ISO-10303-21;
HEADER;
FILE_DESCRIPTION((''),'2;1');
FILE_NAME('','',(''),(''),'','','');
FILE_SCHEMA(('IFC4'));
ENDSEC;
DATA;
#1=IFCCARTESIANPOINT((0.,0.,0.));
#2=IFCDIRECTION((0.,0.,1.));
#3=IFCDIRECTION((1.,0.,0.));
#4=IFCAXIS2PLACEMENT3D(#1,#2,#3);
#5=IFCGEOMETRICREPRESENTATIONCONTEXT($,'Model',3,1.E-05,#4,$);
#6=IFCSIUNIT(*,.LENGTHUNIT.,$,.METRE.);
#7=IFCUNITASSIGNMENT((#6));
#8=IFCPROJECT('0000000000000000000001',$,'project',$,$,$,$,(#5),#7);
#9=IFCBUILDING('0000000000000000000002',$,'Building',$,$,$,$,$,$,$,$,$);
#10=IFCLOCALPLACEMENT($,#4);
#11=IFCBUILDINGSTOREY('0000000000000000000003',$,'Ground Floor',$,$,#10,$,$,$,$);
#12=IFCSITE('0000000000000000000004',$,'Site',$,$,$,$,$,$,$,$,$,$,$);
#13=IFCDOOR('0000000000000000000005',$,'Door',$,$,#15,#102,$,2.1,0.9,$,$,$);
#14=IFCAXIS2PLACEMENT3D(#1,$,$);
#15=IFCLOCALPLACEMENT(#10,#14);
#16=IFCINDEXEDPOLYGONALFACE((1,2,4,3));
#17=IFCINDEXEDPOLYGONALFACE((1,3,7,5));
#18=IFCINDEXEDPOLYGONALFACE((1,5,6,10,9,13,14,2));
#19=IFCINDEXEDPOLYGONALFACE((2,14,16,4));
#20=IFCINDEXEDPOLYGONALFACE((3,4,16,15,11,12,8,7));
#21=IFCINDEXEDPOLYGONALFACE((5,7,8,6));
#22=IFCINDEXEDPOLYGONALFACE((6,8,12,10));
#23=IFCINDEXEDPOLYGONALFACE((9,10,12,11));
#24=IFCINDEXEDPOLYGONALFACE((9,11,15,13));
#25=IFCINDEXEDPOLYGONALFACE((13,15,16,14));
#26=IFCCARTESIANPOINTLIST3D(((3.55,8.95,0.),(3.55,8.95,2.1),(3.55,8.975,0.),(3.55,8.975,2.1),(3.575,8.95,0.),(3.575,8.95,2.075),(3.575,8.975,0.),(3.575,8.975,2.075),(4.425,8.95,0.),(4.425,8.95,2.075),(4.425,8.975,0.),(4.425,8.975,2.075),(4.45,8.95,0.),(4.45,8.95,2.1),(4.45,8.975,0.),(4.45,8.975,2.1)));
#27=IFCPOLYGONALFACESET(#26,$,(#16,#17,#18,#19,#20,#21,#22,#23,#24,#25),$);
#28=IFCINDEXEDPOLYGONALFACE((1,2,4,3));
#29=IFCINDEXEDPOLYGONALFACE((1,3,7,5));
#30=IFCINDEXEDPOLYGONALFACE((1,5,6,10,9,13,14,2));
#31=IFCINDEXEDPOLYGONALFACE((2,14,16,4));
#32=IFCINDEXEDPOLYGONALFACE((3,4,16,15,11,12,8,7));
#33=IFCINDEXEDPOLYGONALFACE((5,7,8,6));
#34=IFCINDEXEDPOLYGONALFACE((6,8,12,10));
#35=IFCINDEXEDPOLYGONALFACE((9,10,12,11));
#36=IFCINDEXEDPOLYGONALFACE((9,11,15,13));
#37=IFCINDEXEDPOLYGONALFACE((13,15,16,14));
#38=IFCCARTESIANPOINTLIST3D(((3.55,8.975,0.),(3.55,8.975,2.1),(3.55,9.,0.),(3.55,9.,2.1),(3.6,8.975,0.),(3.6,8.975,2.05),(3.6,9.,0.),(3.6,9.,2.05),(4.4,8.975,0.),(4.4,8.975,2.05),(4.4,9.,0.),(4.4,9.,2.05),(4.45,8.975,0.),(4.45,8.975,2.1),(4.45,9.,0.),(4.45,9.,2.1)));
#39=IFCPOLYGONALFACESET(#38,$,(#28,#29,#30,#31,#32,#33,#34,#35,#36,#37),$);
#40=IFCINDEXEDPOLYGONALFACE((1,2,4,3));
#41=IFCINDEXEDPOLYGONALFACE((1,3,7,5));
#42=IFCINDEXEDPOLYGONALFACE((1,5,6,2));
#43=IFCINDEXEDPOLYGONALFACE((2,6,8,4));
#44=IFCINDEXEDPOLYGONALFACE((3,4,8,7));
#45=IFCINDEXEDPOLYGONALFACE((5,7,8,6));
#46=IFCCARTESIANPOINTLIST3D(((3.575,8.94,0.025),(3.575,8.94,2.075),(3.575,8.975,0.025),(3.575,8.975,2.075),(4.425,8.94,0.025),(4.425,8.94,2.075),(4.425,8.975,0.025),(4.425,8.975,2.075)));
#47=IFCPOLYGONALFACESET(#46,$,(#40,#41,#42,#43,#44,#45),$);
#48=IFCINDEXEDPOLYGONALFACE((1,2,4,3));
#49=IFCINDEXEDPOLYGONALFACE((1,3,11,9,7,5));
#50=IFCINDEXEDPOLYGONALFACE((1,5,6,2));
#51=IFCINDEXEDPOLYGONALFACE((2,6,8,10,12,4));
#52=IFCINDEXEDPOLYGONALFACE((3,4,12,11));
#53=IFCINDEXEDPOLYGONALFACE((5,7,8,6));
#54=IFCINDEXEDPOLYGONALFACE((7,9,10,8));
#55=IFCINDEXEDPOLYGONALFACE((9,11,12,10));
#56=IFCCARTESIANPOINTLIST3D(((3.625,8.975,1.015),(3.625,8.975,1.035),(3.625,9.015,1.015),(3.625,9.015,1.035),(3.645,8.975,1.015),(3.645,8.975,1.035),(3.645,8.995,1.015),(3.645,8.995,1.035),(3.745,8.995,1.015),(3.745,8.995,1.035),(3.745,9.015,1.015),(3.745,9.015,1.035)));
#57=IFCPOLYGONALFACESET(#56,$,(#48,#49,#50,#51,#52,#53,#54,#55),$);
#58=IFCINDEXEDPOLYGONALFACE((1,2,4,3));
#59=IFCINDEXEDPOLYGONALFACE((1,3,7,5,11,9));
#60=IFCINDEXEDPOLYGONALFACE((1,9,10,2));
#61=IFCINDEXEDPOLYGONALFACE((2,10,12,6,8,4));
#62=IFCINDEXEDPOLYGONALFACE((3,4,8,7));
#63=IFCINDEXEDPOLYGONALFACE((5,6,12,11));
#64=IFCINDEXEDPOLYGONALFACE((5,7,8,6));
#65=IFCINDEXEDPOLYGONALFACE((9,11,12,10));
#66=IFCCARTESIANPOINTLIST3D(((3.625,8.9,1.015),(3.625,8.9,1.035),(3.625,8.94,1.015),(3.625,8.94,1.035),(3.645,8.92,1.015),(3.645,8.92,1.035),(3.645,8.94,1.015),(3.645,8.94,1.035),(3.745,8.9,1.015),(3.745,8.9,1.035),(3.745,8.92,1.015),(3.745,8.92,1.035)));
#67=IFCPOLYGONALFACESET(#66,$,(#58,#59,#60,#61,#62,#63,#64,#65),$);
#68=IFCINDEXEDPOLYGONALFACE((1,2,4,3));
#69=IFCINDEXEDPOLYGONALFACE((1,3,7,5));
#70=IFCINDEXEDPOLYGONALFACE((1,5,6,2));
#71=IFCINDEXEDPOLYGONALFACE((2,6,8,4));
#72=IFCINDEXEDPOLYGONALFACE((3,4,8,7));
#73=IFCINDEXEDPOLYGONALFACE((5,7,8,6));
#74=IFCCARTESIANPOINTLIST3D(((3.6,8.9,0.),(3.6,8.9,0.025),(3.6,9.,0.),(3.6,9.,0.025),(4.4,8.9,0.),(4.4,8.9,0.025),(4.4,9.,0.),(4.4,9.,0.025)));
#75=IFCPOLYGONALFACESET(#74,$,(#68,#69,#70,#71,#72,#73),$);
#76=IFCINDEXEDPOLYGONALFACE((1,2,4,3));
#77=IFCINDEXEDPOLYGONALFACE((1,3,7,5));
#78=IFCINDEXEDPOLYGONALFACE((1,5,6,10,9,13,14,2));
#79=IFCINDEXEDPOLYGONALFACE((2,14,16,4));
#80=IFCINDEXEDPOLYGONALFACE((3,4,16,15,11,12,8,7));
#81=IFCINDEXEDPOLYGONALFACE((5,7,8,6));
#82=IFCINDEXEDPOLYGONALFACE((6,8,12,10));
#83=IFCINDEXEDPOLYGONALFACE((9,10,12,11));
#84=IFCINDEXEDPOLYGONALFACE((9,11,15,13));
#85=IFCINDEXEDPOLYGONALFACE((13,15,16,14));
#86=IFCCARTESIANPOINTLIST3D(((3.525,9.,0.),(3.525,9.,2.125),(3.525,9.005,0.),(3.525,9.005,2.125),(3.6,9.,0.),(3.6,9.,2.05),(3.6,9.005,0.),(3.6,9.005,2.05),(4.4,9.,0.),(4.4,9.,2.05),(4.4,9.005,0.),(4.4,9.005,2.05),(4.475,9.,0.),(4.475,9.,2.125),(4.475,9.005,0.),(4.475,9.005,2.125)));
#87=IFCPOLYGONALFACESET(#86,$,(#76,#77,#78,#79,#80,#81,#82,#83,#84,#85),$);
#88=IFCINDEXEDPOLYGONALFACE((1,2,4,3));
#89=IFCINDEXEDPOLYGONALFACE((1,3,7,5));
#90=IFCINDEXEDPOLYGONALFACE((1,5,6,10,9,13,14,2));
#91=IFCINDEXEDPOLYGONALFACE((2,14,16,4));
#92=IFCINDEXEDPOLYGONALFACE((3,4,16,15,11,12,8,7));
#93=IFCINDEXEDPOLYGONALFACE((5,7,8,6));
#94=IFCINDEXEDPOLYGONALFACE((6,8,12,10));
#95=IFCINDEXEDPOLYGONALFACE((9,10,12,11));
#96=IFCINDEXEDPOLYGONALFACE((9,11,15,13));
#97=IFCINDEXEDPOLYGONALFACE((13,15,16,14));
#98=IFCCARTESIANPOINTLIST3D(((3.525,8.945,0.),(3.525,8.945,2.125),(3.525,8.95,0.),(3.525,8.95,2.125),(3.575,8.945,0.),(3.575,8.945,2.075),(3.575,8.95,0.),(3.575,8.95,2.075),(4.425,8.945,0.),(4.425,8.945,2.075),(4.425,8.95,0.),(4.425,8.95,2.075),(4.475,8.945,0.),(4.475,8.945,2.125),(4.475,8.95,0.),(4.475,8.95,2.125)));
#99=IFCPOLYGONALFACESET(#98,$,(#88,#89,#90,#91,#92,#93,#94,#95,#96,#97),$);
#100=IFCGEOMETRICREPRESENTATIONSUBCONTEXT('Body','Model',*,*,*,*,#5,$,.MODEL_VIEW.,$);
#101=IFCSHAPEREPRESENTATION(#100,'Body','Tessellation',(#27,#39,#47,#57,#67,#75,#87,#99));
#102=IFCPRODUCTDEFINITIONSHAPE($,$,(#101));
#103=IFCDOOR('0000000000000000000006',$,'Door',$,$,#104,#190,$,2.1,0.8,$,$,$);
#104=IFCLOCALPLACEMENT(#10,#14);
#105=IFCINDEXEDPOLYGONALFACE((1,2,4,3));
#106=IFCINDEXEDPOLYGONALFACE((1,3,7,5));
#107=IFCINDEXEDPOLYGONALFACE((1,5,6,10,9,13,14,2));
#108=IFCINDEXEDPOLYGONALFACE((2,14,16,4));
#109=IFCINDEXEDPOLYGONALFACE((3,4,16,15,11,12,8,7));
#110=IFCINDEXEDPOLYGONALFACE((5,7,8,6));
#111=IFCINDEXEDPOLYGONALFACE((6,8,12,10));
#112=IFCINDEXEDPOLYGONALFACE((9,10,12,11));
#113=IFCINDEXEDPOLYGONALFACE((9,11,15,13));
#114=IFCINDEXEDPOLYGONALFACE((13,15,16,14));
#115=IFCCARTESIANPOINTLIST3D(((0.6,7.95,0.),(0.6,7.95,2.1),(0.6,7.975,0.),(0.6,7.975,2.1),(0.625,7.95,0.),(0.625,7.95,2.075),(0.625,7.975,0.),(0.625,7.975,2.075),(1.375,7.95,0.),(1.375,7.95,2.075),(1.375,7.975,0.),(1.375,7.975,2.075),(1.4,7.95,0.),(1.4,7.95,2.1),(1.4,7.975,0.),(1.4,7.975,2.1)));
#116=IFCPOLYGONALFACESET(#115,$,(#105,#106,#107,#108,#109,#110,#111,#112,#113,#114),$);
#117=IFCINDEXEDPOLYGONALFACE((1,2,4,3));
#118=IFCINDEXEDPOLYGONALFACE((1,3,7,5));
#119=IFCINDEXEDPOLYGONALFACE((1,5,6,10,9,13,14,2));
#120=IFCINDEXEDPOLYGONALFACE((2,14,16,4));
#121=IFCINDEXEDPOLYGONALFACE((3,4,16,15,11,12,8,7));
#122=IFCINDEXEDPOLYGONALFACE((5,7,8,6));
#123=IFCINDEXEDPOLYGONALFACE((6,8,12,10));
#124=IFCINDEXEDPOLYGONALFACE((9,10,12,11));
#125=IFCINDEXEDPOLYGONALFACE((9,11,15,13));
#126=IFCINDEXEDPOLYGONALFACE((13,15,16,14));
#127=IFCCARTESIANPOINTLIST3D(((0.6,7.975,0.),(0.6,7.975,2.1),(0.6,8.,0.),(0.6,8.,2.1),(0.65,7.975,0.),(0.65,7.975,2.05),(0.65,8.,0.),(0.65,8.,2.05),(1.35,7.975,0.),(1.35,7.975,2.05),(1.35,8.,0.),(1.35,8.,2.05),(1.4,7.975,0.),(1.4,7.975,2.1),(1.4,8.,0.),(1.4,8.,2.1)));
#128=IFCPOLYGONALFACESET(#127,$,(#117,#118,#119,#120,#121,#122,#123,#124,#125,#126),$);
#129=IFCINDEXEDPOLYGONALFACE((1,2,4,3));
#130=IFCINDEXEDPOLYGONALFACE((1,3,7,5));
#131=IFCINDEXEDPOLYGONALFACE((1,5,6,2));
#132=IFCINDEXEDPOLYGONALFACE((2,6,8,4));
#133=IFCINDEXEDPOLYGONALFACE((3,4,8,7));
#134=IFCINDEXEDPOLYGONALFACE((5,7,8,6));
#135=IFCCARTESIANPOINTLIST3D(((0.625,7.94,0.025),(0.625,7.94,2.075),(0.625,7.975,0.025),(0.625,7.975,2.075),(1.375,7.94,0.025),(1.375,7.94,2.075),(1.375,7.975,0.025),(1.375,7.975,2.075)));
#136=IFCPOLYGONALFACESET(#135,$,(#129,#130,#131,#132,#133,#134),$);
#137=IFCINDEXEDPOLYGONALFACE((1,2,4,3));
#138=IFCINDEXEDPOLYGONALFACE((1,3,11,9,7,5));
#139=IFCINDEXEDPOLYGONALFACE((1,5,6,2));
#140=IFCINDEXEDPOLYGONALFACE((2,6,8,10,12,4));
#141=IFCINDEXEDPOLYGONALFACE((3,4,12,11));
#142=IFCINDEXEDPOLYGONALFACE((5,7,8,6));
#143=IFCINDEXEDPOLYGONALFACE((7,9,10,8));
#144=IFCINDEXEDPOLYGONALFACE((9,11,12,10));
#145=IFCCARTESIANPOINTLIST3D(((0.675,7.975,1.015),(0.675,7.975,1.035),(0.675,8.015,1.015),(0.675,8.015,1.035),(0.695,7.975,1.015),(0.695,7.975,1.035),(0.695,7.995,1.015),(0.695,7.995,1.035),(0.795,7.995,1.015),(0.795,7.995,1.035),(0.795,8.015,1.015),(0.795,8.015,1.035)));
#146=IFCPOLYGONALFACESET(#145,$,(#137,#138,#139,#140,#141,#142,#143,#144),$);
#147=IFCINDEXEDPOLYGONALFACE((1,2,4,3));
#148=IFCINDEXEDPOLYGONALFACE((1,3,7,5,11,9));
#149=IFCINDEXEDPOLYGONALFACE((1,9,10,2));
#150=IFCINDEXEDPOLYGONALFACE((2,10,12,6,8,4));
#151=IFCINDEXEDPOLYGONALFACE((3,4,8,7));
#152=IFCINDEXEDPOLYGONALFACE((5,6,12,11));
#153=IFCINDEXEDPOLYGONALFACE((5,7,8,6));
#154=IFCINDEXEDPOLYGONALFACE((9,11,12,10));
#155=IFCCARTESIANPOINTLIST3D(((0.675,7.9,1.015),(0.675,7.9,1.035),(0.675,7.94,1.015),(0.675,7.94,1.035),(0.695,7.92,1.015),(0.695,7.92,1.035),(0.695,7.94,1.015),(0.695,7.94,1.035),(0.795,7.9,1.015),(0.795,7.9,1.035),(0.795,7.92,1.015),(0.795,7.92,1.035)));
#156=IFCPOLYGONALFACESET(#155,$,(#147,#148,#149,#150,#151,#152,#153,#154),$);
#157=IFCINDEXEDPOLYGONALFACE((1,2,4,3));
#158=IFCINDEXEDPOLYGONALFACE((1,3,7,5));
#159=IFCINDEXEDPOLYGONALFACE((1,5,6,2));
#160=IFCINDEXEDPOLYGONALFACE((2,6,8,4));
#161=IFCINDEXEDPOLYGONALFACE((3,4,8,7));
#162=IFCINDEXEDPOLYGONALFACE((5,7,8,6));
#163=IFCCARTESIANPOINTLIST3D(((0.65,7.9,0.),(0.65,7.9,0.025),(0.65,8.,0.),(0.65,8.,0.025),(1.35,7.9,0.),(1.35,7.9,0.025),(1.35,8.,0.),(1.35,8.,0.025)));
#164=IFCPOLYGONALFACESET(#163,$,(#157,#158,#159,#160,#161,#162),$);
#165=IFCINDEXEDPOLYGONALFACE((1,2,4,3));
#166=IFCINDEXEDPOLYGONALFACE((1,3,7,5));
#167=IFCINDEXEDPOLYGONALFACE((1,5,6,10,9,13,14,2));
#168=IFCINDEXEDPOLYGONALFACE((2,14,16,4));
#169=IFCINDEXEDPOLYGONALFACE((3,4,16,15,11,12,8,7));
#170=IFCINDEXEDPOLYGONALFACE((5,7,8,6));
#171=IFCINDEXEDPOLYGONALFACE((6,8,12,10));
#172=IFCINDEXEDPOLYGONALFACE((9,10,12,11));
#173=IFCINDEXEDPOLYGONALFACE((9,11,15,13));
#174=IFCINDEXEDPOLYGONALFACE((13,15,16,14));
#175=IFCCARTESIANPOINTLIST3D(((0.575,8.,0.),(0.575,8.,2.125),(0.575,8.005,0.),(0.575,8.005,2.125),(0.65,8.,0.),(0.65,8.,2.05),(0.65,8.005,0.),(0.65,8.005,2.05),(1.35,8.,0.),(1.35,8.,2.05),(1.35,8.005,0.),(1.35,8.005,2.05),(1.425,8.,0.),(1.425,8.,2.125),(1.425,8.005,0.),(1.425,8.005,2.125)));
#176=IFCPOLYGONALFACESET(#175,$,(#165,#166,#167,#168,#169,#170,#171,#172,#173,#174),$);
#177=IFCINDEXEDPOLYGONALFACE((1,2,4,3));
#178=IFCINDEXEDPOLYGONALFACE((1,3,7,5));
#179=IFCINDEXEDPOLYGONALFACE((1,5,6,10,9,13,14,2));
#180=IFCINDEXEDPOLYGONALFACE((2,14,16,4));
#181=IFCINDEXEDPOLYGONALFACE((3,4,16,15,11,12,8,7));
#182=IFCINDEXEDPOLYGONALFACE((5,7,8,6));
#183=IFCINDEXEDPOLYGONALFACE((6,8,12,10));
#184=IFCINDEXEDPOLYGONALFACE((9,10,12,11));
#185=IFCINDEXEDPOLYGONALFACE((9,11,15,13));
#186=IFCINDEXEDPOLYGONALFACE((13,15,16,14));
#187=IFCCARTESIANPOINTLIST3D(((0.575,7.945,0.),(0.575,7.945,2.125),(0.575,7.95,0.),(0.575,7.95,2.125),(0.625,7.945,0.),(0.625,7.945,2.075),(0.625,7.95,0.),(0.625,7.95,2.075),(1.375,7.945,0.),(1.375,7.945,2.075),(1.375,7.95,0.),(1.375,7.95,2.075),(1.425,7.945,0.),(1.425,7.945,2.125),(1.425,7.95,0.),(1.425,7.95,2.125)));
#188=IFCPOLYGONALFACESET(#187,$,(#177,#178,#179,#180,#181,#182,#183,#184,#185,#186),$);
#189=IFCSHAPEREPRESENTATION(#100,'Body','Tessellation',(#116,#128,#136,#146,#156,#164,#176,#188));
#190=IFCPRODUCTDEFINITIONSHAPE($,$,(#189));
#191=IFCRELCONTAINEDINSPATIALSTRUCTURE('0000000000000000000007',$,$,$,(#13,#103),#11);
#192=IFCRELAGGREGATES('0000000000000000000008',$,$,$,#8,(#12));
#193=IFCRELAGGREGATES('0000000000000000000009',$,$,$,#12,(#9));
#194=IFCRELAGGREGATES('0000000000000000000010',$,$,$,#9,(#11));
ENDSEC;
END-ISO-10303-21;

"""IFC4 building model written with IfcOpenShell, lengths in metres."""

from ifc_helpers import new_model, si_unit, frame, origin_with_axes, place, context, subcontext, project, spatial, line, indexed_curve, outline, extrude, element, save


model = new_model("IFC4")

# Units and contexts
model_context = context("Model", 3, precision=1e-05, world=origin_with_axes())
body_context = subcontext(model_context, "Body", "Model", "MODEL_VIEW")
ifc_project = project(units=[si_unit("LENGTHUNIT", "METRE")], contexts=[model_context])

# Site, building, storey
site = spatial("IfcSite", under=ifc_project, Name="Site")
building = spatial("IfcBuilding", under=site, Name="Building")
storey_placement = place(None, origin_with_axes())
storey = spatial("IfcBuildingStorey", under=building, at=storey_placement, Name="Ground Floor")

# Doors
door_1_placement = place(storey_placement, frame((4.45, 9.0, 0.0), z_axis=(0.0, 0.0, 1.0), x_axis=(-1.0, 0.0, 0.0)))
element("IfcDoor", 1, at=door_1_placement, inside=storey, Name="Door", OverallHeight=2.1, OverallWidth=0.9, context=body_context, shape_type="SweptSolid", body=[
    extrude(outline(indexed_curve([(0.0, 0.0), (0.0, 2.1), (0.9, 2.1), (0.9, 0.0), (0.875, 0.0), (0.875, 2.075), (0.025, 2.075), (0.025, 0.0)], segments=[line(1, 2, 3, 4, 5, 6, 7, 8, 1)])), frame((0.0, 0.025, 0.0), z_axis=(0.0, -1.0, 0.0), x_axis=(1.0, 0.0, 0.0)), (0.0, 0.0, -1.0), 0.025),
    extrude(outline(indexed_curve([(0.0, 0.0), (0.0, 2.1), (0.9, 2.1), (0.9, 0.0), (0.85, 0.0), (0.85, 2.05), (0.05, 2.05), (0.05, 0.0)], segments=[line(1, 2, 3, 4, 5, 6, 7, 8, 1)])), frame((0.0, 0.0, 0.0), z_axis=(0.0, -1.0, 0.0), x_axis=(1.0, 0.0, 0.0)), (0.0, 0.0, -1.0), 0.025),
    extrude(outline(indexed_curve([(0.0, 0.0), (0.85, 0.0), (0.85, 0.035), (0.0, 0.035)], segments=[line(1, 2, 3, 4, 1)])), frame((0.025, 0.025, 0.025), z_axis=(0.0, 0.0, 1.0), x_axis=(1.0, 0.0, 0.0)), (0.0, 0.0, 1.0), 2.05),
    extrude(outline(indexed_curve([(0.0, 0.0), (0.0, -0.04), (-0.12, -0.04), (-0.12, -0.02), (-0.02, -0.02), (-0.02, 0.0)], segments=[line(1, 2, 3, 4, 5, 6, 1)])), frame((0.825, 0.025, 1.015), z_axis=(0.0, 0.0, 1.0), x_axis=(1.0, 0.0, 0.0)), (0.0, 0.0, 1.0), 0.02),
    extrude(outline(indexed_curve([(0.0, 0.0), (0.0, 0.04), (-0.12, 0.04), (-0.12, 0.02), (-0.02, 0.02), (-0.02, 0.0)], segments=[line(1, 2, 3, 4, 5, 6, 1)])), frame((0.825, 0.06, 1.015), z_axis=(0.0, 0.0, 1.0), x_axis=(1.0, 0.0, 0.0)), (0.0, 0.0, 1.0), 0.02),
    extrude(outline(indexed_curve([(0.0, 0.0), (0.8, 0.0), (0.8, 0.1), (0.0, 0.1)], segments=[line(1, 2, 3, 4, 1)])), frame((0.05, 0.0, 0.0), z_axis=(0.0, 0.0, 1.0), x_axis=(1.0, 0.0, 0.0)), (0.0, 0.0, 1.0), 0.025),
    extrude(outline(indexed_curve([(0.0, 0.0), (0.0, 2.125), (0.95, 2.125), (0.95, 0.0), (0.875, 0.0), (0.875, 2.05), (0.075, 2.05), (0.075, 0.0)], segments=[line(1, 2, 3, 4, 5, 6, 7, 8, 1)])), frame((-0.025, -0.005, 0.0), z_axis=(0.0, -1.0, 0.0), x_axis=(1.0, 0.0, 0.0)), (0.0, 0.0, -1.0), 0.005),
    extrude(outline(indexed_curve([(0.0, 0.0), (0.0, 2.125), (0.95, 2.125), (0.95, 0.0), (0.9, 0.0), (0.9, 2.075), (0.05, 2.075), (0.05, 0.0)], segments=[line(1, 2, 3, 4, 5, 6, 7, 8, 1)])), frame((-0.025, 0.05, 0.0), z_axis=(0.0, -1.0, 0.0), x_axis=(1.0, 0.0, 0.0)), (0.0, 0.0, -1.0), 0.005),
])
door_2_placement = place(storey_placement, frame((1.4, 8.0, 0.0), z_axis=(0.0, 0.0, 1.0), x_axis=(-1.0, 0.0, 0.0)))
element("IfcDoor", 2, at=door_2_placement, inside=storey, Name="Door", OverallHeight=2.1, OverallWidth=0.8, context=body_context, shape_type="SweptSolid", body=[
    extrude(outline(indexed_curve([(0.0, 0.0), (0.0, 2.1), (0.8, 2.1), (0.8, 0.0), (0.775, 0.0), (0.775, 2.075), (0.025, 2.075), (0.025, 0.0)], segments=[line(1, 2, 3, 4, 5, 6, 7, 8, 1)])), frame((0.0, 0.025, 0.0), z_axis=(0.0, -1.0, 0.0), x_axis=(1.0, 0.0, 0.0)), (0.0, 0.0, -1.0), 0.025),
    extrude(outline(indexed_curve([(0.0, 0.0), (0.0, 2.1), (0.8, 2.1), (0.8, 0.0), (0.75, 0.0), (0.75, 2.05), (0.05, 2.05), (0.05, 0.0)], segments=[line(1, 2, 3, 4, 5, 6, 7, 8, 1)])), frame((0.0, 0.0, 0.0), z_axis=(0.0, -1.0, 0.0), x_axis=(1.0, 0.0, 0.0)), (0.0, 0.0, -1.0), 0.025),
    extrude(outline(indexed_curve([(0.0, 0.0), (0.75, 0.0), (0.75, 0.035), (0.0, 0.035)], segments=[line(1, 2, 3, 4, 1)])), frame((0.025, 0.025, 0.025), z_axis=(0.0, 0.0, 1.0), x_axis=(1.0, 0.0, 0.0)), (0.0, 0.0, 1.0), 2.05),
    extrude(outline(indexed_curve([(0.0, 0.0), (0.0, -0.04), (-0.12, -0.04), (-0.12, -0.02), (-0.02, -0.02), (-0.02, 0.0)], segments=[line(1, 2, 3, 4, 5, 6, 1)])), frame((0.725, 0.025, 1.015), z_axis=(0.0, 0.0, 1.0), x_axis=(1.0, 0.0, 0.0)), (0.0, 0.0, 1.0), 0.02),
    extrude(outline(indexed_curve([(0.0, 0.0), (0.0, 0.04), (-0.12, 0.04), (-0.12, 0.02), (-0.02, 0.02), (-0.02, 0.0)], segments=[line(1, 2, 3, 4, 5, 6, 1)])), frame((0.725, 0.06, 1.015), z_axis=(0.0, 0.0, 1.0), x_axis=(1.0, 0.0, 0.0)), (0.0, 0.0, 1.0), 0.02),
    extrude(outline(indexed_curve([(0.0, 0.0), (0.7, 0.0), (0.7, 0.1), (0.0, 0.1)], segments=[line(1, 2, 3, 4, 1)])), frame((0.05, 0.0, 0.0), z_axis=(0.0, 0.0, 1.0), x_axis=(1.0, 0.0, 0.0)), (0.0, 0.0, 1.0), 0.025),
    extrude(outline(indexed_curve([(0.0, 0.0), (0.0, 2.125), (0.85, 2.125), (0.85, 0.0), (0.775, 0.0), (0.775, 2.05), (0.075, 2.05), (0.075, 0.0)], segments=[line(1, 2, 3, 4, 5, 6, 7, 8, 1)])), frame((-0.025, -0.005, 0.0), z_axis=(0.0, -1.0, 0.0), x_axis=(1.0, 0.0, 0.0)), (0.0, 0.0, -1.0), 0.005),
    extrude(outline(indexed_curve([(0.0, 0.0), (0.0, 2.125), (0.85, 2.125), (0.85, 0.0), (0.8, 0.0), (0.8, 2.075), (0.05, 2.075), (0.05, 0.0)], segments=[line(1, 2, 3, 4, 5, 6, 7, 8, 1)])), frame((-0.025, 0.05, 0.0), z_axis=(0.0, -1.0, 0.0), x_axis=(1.0, 0.0, 0.0)), (0.0, 0.0, -1.0), 0.005),
])

save(model, "model.ifc")
